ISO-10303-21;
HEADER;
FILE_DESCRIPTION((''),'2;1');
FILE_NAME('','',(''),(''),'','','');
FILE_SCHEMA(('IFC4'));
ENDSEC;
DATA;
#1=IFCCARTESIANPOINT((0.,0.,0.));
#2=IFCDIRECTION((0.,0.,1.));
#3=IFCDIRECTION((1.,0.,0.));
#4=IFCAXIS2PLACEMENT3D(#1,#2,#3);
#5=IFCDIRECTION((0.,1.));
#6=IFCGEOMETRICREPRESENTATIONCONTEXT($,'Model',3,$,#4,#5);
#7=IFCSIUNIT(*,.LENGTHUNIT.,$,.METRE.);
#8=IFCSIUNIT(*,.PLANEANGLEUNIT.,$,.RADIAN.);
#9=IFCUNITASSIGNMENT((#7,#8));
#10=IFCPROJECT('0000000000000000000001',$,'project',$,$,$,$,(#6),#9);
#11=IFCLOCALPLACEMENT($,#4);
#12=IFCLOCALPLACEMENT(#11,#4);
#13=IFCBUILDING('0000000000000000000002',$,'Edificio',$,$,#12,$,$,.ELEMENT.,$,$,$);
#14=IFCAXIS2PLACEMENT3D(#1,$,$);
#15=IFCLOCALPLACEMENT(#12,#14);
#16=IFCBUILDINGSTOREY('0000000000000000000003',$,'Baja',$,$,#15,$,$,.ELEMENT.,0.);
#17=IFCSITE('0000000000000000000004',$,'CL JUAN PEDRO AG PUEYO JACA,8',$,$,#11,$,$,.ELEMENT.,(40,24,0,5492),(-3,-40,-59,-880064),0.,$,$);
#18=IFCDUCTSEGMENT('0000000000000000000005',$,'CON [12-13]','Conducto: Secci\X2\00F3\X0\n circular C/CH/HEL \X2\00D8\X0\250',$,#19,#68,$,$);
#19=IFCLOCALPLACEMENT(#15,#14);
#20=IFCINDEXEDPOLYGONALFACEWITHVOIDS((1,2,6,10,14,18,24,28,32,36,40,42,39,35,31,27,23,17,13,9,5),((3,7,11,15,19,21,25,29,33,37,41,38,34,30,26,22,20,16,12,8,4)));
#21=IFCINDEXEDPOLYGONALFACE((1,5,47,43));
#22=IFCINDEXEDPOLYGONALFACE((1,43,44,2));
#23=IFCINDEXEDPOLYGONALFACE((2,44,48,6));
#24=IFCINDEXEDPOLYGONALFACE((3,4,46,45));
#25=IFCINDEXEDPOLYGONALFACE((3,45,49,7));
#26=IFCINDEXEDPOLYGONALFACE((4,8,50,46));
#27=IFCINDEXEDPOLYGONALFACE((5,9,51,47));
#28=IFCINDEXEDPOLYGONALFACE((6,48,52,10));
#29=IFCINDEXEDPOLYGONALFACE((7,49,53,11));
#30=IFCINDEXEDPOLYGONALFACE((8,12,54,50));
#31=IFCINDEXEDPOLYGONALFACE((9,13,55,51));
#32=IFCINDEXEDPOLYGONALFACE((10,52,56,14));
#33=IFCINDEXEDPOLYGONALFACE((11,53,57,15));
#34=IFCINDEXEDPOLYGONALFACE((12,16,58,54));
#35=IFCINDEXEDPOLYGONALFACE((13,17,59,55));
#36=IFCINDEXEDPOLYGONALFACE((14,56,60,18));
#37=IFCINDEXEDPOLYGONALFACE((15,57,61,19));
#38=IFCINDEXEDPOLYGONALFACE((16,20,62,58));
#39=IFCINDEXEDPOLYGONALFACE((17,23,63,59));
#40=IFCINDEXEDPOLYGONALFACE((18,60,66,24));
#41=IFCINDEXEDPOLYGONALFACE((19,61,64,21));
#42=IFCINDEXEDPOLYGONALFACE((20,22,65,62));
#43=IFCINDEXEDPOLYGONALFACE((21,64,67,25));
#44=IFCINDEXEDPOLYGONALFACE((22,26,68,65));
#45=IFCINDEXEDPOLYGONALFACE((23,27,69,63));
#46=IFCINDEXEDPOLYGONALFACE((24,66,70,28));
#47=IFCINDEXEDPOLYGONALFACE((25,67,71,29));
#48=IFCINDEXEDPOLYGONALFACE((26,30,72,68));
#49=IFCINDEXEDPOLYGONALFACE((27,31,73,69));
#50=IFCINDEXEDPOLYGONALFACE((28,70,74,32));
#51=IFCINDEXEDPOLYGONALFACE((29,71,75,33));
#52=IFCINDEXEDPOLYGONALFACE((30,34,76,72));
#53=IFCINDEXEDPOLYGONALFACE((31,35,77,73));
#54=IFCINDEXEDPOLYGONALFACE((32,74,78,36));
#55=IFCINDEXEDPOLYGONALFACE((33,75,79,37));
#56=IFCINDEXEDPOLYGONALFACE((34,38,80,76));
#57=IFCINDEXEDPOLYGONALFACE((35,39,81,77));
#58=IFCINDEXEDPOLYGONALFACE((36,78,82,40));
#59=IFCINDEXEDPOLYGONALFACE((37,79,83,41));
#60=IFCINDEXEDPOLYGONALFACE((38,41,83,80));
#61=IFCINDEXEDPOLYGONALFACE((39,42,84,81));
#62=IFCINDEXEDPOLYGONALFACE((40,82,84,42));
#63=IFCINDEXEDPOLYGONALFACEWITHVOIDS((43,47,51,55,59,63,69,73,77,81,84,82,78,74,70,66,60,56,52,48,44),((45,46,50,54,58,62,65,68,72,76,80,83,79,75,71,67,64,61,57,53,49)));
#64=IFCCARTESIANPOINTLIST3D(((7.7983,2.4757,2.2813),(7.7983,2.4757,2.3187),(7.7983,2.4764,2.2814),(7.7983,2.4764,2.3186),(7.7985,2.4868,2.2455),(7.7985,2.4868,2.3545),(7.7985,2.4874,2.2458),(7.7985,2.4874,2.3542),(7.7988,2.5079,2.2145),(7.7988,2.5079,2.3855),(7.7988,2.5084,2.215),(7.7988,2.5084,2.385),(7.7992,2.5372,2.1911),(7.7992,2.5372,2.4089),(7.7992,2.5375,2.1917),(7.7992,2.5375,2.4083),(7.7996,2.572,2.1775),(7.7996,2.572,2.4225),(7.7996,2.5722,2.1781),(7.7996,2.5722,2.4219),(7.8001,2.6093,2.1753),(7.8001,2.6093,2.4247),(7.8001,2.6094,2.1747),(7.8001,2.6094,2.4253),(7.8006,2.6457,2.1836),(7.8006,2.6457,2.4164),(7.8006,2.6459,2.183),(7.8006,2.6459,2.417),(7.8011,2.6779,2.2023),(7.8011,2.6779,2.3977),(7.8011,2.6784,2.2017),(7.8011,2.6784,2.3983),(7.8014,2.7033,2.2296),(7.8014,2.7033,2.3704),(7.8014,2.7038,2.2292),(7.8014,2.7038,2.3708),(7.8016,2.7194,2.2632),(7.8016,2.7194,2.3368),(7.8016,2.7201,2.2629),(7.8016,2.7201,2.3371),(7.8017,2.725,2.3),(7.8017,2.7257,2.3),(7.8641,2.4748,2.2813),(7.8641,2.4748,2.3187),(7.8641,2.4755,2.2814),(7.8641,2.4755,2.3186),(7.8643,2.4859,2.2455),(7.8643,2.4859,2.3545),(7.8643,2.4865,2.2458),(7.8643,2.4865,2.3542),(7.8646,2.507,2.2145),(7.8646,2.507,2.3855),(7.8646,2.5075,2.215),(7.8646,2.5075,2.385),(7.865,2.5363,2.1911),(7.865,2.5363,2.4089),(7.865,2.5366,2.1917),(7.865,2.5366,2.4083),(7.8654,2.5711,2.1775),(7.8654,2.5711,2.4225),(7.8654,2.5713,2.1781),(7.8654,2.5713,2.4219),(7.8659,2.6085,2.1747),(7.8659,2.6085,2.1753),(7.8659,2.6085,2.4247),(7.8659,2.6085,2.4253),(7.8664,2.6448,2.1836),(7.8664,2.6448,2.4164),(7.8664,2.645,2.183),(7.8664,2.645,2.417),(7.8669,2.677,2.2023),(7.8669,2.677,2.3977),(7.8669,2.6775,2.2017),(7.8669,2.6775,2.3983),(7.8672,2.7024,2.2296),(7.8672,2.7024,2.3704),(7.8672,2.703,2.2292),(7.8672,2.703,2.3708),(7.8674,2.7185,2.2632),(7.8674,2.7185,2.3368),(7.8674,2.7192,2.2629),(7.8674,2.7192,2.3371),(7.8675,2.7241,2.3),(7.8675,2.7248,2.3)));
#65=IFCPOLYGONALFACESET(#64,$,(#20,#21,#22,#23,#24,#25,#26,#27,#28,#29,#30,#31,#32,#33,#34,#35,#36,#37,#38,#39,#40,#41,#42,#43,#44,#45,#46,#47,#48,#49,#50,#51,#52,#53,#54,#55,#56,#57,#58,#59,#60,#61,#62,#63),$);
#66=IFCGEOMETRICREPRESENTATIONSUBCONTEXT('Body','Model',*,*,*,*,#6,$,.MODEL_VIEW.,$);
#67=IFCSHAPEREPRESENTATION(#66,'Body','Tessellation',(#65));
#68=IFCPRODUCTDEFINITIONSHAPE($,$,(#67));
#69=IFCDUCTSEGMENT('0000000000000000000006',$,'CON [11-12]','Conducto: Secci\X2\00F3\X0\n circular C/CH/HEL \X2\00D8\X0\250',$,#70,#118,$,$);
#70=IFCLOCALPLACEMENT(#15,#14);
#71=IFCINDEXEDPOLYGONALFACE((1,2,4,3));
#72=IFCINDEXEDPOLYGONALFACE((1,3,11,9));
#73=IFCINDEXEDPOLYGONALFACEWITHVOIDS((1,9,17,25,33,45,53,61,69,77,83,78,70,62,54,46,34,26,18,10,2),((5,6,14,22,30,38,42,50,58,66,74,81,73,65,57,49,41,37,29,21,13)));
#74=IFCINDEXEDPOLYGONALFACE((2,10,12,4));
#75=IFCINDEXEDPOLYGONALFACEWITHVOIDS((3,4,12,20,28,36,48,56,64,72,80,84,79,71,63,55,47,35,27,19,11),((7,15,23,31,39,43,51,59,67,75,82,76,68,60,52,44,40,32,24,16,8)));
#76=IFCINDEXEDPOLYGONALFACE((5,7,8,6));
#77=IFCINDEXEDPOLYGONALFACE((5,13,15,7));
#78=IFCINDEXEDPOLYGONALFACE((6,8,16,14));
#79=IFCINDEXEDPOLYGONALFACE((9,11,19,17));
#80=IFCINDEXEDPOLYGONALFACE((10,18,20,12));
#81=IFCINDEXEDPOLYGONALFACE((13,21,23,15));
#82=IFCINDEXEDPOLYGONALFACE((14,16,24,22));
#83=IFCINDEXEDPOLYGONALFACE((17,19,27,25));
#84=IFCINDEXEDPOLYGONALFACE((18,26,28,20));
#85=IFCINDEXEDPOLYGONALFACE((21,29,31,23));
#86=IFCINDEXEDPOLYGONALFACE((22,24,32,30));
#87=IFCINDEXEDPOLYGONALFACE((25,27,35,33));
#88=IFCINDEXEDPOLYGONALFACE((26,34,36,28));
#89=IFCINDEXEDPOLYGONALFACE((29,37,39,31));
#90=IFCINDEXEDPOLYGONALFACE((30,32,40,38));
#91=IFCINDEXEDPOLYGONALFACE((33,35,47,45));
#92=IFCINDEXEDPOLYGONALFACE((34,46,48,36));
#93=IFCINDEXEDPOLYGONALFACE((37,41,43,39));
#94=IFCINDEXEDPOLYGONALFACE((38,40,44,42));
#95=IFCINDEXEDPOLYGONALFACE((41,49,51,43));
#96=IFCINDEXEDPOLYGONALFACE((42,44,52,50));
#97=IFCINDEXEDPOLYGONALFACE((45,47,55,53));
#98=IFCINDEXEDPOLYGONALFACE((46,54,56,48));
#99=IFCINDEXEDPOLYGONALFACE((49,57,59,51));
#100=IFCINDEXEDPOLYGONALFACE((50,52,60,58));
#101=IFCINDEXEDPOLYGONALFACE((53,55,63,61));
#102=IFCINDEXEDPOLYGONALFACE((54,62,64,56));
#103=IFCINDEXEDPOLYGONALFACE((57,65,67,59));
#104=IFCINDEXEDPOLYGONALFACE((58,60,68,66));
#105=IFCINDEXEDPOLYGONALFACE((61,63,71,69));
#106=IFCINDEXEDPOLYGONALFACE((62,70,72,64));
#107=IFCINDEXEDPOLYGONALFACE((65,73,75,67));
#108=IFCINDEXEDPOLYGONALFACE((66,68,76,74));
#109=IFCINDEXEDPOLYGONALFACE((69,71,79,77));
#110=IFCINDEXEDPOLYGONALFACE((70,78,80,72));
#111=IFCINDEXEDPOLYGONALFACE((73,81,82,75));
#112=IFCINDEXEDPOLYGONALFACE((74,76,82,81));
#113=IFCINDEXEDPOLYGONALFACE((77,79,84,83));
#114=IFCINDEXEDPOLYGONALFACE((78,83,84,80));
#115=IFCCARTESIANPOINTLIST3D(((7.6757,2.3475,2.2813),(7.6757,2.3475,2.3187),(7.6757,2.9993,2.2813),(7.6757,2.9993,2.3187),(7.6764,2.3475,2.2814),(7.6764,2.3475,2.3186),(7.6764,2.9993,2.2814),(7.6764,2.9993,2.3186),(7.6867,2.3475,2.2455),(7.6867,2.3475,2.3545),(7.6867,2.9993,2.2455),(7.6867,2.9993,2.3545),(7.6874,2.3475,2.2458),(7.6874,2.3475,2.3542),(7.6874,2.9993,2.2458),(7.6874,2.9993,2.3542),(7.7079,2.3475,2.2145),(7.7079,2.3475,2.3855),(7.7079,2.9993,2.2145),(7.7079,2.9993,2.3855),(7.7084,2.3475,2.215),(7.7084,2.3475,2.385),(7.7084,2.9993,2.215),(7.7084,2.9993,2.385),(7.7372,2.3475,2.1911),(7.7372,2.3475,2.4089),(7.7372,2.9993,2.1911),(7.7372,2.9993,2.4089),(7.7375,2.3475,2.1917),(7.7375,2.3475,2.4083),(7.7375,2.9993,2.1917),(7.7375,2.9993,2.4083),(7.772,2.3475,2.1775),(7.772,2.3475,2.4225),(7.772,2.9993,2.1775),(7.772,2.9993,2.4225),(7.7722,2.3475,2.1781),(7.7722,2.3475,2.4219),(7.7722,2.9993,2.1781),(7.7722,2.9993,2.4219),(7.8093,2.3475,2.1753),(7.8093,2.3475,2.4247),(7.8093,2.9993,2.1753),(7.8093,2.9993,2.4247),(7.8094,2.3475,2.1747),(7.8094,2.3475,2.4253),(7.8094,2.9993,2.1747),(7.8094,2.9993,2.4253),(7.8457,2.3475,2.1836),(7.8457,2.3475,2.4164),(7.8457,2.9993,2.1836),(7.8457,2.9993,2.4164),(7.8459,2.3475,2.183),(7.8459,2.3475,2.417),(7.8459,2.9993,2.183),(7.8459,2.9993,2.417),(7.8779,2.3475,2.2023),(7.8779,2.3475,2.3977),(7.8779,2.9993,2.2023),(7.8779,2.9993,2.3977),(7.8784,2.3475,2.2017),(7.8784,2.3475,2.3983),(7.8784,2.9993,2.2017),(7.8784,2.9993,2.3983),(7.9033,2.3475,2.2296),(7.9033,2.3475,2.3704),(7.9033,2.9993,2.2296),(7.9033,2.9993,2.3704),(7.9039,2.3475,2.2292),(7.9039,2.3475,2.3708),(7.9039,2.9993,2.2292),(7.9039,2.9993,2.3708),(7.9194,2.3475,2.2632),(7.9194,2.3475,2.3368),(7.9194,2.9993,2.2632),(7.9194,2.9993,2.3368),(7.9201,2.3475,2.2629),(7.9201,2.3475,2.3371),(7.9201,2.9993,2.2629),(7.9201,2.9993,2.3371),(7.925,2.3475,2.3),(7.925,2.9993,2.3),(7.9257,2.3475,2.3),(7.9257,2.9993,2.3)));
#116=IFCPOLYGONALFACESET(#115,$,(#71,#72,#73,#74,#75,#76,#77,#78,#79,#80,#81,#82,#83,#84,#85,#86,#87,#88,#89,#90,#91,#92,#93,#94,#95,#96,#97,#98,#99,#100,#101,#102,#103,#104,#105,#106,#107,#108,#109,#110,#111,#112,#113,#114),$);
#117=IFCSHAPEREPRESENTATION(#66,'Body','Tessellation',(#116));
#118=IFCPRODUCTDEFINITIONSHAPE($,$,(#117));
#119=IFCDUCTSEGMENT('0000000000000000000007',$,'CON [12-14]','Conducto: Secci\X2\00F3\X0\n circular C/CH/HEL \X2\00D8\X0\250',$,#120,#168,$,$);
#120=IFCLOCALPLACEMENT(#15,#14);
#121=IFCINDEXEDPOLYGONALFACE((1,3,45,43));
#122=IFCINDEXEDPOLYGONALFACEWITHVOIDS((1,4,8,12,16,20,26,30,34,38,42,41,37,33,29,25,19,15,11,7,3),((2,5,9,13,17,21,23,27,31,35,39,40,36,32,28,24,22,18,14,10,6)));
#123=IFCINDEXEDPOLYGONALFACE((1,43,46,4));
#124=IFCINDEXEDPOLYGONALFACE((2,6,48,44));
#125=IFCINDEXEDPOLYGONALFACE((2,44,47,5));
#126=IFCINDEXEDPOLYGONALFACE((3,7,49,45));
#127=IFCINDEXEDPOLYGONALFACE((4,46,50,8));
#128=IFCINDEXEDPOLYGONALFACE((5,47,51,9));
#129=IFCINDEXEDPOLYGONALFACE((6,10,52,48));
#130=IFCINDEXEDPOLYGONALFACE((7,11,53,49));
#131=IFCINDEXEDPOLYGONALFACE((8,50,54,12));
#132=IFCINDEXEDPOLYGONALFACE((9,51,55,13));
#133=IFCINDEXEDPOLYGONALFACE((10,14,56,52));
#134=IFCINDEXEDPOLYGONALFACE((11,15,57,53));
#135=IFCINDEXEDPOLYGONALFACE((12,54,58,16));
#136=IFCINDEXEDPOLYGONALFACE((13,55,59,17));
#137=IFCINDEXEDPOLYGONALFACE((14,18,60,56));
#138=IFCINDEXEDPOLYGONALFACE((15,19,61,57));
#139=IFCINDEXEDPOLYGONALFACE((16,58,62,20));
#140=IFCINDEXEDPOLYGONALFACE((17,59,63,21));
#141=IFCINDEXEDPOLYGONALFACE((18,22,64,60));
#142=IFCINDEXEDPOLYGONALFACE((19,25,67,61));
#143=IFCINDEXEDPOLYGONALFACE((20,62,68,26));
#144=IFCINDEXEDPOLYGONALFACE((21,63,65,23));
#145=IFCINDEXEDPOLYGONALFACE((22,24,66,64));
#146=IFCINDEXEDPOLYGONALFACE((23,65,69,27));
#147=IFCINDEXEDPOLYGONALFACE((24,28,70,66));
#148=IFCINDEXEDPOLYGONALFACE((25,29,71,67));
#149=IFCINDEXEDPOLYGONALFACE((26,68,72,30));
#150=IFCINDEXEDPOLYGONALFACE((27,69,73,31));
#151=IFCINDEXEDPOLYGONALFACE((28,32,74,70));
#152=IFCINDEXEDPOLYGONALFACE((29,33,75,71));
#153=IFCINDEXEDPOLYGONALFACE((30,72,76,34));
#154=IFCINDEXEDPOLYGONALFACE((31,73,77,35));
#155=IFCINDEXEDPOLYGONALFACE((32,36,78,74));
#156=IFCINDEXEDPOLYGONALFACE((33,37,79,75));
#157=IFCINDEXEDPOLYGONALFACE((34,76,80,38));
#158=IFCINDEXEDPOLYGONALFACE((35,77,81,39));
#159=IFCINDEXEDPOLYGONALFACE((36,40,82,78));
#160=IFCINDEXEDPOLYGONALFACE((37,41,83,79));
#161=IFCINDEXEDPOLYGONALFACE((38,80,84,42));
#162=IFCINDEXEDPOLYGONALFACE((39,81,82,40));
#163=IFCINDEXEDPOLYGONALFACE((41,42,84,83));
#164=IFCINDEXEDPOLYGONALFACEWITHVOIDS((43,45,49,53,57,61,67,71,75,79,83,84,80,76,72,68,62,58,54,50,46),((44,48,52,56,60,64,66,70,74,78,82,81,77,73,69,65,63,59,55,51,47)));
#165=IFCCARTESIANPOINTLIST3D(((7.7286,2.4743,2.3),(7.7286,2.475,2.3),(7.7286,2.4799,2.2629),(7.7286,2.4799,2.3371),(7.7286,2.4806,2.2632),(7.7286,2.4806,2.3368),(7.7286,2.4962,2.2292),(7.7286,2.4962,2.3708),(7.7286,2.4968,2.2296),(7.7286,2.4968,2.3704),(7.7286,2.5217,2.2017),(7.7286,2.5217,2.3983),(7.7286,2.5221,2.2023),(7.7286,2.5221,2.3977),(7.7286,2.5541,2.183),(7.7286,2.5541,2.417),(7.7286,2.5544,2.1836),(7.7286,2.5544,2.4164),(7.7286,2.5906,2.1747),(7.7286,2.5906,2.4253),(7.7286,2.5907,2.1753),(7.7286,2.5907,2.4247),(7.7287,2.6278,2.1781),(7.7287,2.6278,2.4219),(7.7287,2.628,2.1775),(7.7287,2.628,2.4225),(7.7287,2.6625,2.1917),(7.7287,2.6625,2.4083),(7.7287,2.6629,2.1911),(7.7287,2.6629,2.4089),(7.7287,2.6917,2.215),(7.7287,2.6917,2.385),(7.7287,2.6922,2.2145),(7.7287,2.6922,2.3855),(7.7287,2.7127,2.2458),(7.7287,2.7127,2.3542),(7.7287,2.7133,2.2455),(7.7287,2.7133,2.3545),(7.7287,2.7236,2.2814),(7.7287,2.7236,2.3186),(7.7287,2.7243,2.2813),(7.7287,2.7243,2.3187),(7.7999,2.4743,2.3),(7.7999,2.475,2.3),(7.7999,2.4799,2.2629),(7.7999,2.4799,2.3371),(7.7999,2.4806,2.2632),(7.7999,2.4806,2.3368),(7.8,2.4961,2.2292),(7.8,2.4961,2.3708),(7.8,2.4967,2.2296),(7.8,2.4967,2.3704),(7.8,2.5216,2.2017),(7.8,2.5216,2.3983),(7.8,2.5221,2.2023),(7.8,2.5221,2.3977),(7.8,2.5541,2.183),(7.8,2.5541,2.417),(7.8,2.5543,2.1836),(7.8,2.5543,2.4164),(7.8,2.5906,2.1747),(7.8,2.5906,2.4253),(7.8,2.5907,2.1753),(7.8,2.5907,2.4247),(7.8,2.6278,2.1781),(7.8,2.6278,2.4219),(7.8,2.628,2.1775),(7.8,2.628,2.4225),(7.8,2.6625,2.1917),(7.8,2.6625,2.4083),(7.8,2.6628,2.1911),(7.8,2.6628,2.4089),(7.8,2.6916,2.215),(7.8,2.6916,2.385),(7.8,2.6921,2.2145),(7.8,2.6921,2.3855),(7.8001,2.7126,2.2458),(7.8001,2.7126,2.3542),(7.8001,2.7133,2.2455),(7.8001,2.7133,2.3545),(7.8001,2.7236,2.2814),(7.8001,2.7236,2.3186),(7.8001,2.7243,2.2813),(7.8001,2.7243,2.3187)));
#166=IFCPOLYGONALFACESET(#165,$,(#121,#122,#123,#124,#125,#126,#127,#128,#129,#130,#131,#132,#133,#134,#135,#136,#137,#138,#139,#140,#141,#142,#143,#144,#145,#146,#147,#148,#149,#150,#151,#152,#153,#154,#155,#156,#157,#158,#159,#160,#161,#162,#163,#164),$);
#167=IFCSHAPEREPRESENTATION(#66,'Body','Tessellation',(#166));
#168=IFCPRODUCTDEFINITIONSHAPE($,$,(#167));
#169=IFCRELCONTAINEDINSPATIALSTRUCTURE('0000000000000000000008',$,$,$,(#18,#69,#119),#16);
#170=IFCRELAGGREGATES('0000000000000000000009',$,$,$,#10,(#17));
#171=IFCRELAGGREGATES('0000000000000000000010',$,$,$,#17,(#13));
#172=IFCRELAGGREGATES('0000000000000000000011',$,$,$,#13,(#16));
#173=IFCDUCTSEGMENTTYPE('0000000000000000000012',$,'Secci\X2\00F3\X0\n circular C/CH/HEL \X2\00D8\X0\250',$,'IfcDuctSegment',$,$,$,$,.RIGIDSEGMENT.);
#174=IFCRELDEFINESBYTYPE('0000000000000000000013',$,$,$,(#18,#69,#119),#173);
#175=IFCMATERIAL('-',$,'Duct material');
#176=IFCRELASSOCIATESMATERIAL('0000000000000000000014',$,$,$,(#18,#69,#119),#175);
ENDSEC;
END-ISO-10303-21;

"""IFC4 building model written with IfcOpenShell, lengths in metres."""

from ifc_helpers import new_model, si_unit, direction, frame, origin, origin_with_axes, origin_2d_with_axis, place, context, subcontext, project, spatial, hollow_circle, extrude, material, type_object, element, save


model = new_model("IFC4")

# Units and contexts
model_context = context("Model", 3, world=origin_with_axes(), true_north=direction((0.0, 1.0)))
body_context = subcontext(model_context, "Body", "Model", "MODEL_VIEW")
ifc_project = project(units=[si_unit("LENGTHUNIT", "METRE"), si_unit("PLANEANGLEUNIT", "RADIAN")], contexts=[model_context])

# Site, building, storey
site_placement = place(None, origin_with_axes())
site = spatial("IfcSite", under=ifc_project, at=site_placement, Name="CL JUAN PEDRO AG PUEYO JACA,8", CompositionType="ELEMENT", RefLatitude=(40, 24, 0, 5492), RefLongitude=(-3, -40, -59, -880064), RefElevation=0.0)
building_placement = place(site_placement, origin_with_axes())
building = spatial("IfcBuilding", under=site, at=building_placement, Name="Edificio", CompositionType="ELEMENT")
storey_placement = place(building_placement, origin())
storey = spatial("IfcBuildingStorey", under=building, at=storey_placement, Name="Baja", CompositionType="ELEMENT", Elevation=0.0)

# Duct segments
ifc_material_1 = material(Name="-", Category="Duct material")
duct_segment_type_1 = type_object("IfcDuctSegmentType", Name="Sección circular C/CH/HEL Ø250", ApplicableOccurrence="IfcDuctSegment", PredefinedType="RIGIDSEGMENT")
duct_segment_1_placement = place(storey_placement, origin_with_axes())
element("IfcDuctSegment", 1, at=duct_segment_1_placement, inside=storey, type_object=duct_segment_type_1, material=ifc_material_1, Name="CON [12-13]", Description="Conducto: Sección circular C/CH/HEL Ø250", context=body_context, shape_type="SweptSolid", body=[
    extrude(hollow_circle(Radius=0.1257, WallThickness=0.0007, at=origin_2d_with_axis()), frame((7.8, 2.6, 2.3), z_axis=(0.999909, -0.013515, 0.0), x_axis=(0.013515, 0.999909, 0.0)), (0.0, 0.0, 1.0), 0.0658),
])
duct_segment_2_placement = place(storey_placement, origin_with_axes())
element("IfcDuctSegment", 2, at=duct_segment_2_placement, inside=storey, type_object=duct_segment_type_1, material=ifc_material_1, Name="CON [11-12]", Description="Conducto: Sección circular C/CH/HEL Ø250", context=body_context, shape_type="SweptSolid", body=[
    extrude(hollow_circle(Radius=0.1257, WallThickness=0.0007, at=origin_2d_with_axis()), frame((7.8, 2.9993, 2.3), z_axis=(0.0, -1.0, 0.0), x_axis=(1.0, 0.0, 0.0)), (0.0, 0.0, 1.0), 0.6518),
])
duct_segment_3_placement = place(storey_placement, origin_with_axes())
element("IfcDuctSegment", 3, at=duct_segment_3_placement, inside=storey, type_object=duct_segment_type_1, material=ifc_material_1, Name="CON [12-14]", Description="Conducto: Sección circular C/CH/HEL Ø250", context=body_context, shape_type="SweptSolid", body=[
    extrude(hollow_circle(Radius=0.1257, WallThickness=0.0007, at=origin_2d_with_axis()), frame((7.8, 2.6, 2.3), z_axis=(-1.0, 0.000478, 0.0), x_axis=(-0.000478, -1.0, 0.0)), (0.0, 0.0, 1.0), 0.0714),
])

save(model, "model.ifc")
